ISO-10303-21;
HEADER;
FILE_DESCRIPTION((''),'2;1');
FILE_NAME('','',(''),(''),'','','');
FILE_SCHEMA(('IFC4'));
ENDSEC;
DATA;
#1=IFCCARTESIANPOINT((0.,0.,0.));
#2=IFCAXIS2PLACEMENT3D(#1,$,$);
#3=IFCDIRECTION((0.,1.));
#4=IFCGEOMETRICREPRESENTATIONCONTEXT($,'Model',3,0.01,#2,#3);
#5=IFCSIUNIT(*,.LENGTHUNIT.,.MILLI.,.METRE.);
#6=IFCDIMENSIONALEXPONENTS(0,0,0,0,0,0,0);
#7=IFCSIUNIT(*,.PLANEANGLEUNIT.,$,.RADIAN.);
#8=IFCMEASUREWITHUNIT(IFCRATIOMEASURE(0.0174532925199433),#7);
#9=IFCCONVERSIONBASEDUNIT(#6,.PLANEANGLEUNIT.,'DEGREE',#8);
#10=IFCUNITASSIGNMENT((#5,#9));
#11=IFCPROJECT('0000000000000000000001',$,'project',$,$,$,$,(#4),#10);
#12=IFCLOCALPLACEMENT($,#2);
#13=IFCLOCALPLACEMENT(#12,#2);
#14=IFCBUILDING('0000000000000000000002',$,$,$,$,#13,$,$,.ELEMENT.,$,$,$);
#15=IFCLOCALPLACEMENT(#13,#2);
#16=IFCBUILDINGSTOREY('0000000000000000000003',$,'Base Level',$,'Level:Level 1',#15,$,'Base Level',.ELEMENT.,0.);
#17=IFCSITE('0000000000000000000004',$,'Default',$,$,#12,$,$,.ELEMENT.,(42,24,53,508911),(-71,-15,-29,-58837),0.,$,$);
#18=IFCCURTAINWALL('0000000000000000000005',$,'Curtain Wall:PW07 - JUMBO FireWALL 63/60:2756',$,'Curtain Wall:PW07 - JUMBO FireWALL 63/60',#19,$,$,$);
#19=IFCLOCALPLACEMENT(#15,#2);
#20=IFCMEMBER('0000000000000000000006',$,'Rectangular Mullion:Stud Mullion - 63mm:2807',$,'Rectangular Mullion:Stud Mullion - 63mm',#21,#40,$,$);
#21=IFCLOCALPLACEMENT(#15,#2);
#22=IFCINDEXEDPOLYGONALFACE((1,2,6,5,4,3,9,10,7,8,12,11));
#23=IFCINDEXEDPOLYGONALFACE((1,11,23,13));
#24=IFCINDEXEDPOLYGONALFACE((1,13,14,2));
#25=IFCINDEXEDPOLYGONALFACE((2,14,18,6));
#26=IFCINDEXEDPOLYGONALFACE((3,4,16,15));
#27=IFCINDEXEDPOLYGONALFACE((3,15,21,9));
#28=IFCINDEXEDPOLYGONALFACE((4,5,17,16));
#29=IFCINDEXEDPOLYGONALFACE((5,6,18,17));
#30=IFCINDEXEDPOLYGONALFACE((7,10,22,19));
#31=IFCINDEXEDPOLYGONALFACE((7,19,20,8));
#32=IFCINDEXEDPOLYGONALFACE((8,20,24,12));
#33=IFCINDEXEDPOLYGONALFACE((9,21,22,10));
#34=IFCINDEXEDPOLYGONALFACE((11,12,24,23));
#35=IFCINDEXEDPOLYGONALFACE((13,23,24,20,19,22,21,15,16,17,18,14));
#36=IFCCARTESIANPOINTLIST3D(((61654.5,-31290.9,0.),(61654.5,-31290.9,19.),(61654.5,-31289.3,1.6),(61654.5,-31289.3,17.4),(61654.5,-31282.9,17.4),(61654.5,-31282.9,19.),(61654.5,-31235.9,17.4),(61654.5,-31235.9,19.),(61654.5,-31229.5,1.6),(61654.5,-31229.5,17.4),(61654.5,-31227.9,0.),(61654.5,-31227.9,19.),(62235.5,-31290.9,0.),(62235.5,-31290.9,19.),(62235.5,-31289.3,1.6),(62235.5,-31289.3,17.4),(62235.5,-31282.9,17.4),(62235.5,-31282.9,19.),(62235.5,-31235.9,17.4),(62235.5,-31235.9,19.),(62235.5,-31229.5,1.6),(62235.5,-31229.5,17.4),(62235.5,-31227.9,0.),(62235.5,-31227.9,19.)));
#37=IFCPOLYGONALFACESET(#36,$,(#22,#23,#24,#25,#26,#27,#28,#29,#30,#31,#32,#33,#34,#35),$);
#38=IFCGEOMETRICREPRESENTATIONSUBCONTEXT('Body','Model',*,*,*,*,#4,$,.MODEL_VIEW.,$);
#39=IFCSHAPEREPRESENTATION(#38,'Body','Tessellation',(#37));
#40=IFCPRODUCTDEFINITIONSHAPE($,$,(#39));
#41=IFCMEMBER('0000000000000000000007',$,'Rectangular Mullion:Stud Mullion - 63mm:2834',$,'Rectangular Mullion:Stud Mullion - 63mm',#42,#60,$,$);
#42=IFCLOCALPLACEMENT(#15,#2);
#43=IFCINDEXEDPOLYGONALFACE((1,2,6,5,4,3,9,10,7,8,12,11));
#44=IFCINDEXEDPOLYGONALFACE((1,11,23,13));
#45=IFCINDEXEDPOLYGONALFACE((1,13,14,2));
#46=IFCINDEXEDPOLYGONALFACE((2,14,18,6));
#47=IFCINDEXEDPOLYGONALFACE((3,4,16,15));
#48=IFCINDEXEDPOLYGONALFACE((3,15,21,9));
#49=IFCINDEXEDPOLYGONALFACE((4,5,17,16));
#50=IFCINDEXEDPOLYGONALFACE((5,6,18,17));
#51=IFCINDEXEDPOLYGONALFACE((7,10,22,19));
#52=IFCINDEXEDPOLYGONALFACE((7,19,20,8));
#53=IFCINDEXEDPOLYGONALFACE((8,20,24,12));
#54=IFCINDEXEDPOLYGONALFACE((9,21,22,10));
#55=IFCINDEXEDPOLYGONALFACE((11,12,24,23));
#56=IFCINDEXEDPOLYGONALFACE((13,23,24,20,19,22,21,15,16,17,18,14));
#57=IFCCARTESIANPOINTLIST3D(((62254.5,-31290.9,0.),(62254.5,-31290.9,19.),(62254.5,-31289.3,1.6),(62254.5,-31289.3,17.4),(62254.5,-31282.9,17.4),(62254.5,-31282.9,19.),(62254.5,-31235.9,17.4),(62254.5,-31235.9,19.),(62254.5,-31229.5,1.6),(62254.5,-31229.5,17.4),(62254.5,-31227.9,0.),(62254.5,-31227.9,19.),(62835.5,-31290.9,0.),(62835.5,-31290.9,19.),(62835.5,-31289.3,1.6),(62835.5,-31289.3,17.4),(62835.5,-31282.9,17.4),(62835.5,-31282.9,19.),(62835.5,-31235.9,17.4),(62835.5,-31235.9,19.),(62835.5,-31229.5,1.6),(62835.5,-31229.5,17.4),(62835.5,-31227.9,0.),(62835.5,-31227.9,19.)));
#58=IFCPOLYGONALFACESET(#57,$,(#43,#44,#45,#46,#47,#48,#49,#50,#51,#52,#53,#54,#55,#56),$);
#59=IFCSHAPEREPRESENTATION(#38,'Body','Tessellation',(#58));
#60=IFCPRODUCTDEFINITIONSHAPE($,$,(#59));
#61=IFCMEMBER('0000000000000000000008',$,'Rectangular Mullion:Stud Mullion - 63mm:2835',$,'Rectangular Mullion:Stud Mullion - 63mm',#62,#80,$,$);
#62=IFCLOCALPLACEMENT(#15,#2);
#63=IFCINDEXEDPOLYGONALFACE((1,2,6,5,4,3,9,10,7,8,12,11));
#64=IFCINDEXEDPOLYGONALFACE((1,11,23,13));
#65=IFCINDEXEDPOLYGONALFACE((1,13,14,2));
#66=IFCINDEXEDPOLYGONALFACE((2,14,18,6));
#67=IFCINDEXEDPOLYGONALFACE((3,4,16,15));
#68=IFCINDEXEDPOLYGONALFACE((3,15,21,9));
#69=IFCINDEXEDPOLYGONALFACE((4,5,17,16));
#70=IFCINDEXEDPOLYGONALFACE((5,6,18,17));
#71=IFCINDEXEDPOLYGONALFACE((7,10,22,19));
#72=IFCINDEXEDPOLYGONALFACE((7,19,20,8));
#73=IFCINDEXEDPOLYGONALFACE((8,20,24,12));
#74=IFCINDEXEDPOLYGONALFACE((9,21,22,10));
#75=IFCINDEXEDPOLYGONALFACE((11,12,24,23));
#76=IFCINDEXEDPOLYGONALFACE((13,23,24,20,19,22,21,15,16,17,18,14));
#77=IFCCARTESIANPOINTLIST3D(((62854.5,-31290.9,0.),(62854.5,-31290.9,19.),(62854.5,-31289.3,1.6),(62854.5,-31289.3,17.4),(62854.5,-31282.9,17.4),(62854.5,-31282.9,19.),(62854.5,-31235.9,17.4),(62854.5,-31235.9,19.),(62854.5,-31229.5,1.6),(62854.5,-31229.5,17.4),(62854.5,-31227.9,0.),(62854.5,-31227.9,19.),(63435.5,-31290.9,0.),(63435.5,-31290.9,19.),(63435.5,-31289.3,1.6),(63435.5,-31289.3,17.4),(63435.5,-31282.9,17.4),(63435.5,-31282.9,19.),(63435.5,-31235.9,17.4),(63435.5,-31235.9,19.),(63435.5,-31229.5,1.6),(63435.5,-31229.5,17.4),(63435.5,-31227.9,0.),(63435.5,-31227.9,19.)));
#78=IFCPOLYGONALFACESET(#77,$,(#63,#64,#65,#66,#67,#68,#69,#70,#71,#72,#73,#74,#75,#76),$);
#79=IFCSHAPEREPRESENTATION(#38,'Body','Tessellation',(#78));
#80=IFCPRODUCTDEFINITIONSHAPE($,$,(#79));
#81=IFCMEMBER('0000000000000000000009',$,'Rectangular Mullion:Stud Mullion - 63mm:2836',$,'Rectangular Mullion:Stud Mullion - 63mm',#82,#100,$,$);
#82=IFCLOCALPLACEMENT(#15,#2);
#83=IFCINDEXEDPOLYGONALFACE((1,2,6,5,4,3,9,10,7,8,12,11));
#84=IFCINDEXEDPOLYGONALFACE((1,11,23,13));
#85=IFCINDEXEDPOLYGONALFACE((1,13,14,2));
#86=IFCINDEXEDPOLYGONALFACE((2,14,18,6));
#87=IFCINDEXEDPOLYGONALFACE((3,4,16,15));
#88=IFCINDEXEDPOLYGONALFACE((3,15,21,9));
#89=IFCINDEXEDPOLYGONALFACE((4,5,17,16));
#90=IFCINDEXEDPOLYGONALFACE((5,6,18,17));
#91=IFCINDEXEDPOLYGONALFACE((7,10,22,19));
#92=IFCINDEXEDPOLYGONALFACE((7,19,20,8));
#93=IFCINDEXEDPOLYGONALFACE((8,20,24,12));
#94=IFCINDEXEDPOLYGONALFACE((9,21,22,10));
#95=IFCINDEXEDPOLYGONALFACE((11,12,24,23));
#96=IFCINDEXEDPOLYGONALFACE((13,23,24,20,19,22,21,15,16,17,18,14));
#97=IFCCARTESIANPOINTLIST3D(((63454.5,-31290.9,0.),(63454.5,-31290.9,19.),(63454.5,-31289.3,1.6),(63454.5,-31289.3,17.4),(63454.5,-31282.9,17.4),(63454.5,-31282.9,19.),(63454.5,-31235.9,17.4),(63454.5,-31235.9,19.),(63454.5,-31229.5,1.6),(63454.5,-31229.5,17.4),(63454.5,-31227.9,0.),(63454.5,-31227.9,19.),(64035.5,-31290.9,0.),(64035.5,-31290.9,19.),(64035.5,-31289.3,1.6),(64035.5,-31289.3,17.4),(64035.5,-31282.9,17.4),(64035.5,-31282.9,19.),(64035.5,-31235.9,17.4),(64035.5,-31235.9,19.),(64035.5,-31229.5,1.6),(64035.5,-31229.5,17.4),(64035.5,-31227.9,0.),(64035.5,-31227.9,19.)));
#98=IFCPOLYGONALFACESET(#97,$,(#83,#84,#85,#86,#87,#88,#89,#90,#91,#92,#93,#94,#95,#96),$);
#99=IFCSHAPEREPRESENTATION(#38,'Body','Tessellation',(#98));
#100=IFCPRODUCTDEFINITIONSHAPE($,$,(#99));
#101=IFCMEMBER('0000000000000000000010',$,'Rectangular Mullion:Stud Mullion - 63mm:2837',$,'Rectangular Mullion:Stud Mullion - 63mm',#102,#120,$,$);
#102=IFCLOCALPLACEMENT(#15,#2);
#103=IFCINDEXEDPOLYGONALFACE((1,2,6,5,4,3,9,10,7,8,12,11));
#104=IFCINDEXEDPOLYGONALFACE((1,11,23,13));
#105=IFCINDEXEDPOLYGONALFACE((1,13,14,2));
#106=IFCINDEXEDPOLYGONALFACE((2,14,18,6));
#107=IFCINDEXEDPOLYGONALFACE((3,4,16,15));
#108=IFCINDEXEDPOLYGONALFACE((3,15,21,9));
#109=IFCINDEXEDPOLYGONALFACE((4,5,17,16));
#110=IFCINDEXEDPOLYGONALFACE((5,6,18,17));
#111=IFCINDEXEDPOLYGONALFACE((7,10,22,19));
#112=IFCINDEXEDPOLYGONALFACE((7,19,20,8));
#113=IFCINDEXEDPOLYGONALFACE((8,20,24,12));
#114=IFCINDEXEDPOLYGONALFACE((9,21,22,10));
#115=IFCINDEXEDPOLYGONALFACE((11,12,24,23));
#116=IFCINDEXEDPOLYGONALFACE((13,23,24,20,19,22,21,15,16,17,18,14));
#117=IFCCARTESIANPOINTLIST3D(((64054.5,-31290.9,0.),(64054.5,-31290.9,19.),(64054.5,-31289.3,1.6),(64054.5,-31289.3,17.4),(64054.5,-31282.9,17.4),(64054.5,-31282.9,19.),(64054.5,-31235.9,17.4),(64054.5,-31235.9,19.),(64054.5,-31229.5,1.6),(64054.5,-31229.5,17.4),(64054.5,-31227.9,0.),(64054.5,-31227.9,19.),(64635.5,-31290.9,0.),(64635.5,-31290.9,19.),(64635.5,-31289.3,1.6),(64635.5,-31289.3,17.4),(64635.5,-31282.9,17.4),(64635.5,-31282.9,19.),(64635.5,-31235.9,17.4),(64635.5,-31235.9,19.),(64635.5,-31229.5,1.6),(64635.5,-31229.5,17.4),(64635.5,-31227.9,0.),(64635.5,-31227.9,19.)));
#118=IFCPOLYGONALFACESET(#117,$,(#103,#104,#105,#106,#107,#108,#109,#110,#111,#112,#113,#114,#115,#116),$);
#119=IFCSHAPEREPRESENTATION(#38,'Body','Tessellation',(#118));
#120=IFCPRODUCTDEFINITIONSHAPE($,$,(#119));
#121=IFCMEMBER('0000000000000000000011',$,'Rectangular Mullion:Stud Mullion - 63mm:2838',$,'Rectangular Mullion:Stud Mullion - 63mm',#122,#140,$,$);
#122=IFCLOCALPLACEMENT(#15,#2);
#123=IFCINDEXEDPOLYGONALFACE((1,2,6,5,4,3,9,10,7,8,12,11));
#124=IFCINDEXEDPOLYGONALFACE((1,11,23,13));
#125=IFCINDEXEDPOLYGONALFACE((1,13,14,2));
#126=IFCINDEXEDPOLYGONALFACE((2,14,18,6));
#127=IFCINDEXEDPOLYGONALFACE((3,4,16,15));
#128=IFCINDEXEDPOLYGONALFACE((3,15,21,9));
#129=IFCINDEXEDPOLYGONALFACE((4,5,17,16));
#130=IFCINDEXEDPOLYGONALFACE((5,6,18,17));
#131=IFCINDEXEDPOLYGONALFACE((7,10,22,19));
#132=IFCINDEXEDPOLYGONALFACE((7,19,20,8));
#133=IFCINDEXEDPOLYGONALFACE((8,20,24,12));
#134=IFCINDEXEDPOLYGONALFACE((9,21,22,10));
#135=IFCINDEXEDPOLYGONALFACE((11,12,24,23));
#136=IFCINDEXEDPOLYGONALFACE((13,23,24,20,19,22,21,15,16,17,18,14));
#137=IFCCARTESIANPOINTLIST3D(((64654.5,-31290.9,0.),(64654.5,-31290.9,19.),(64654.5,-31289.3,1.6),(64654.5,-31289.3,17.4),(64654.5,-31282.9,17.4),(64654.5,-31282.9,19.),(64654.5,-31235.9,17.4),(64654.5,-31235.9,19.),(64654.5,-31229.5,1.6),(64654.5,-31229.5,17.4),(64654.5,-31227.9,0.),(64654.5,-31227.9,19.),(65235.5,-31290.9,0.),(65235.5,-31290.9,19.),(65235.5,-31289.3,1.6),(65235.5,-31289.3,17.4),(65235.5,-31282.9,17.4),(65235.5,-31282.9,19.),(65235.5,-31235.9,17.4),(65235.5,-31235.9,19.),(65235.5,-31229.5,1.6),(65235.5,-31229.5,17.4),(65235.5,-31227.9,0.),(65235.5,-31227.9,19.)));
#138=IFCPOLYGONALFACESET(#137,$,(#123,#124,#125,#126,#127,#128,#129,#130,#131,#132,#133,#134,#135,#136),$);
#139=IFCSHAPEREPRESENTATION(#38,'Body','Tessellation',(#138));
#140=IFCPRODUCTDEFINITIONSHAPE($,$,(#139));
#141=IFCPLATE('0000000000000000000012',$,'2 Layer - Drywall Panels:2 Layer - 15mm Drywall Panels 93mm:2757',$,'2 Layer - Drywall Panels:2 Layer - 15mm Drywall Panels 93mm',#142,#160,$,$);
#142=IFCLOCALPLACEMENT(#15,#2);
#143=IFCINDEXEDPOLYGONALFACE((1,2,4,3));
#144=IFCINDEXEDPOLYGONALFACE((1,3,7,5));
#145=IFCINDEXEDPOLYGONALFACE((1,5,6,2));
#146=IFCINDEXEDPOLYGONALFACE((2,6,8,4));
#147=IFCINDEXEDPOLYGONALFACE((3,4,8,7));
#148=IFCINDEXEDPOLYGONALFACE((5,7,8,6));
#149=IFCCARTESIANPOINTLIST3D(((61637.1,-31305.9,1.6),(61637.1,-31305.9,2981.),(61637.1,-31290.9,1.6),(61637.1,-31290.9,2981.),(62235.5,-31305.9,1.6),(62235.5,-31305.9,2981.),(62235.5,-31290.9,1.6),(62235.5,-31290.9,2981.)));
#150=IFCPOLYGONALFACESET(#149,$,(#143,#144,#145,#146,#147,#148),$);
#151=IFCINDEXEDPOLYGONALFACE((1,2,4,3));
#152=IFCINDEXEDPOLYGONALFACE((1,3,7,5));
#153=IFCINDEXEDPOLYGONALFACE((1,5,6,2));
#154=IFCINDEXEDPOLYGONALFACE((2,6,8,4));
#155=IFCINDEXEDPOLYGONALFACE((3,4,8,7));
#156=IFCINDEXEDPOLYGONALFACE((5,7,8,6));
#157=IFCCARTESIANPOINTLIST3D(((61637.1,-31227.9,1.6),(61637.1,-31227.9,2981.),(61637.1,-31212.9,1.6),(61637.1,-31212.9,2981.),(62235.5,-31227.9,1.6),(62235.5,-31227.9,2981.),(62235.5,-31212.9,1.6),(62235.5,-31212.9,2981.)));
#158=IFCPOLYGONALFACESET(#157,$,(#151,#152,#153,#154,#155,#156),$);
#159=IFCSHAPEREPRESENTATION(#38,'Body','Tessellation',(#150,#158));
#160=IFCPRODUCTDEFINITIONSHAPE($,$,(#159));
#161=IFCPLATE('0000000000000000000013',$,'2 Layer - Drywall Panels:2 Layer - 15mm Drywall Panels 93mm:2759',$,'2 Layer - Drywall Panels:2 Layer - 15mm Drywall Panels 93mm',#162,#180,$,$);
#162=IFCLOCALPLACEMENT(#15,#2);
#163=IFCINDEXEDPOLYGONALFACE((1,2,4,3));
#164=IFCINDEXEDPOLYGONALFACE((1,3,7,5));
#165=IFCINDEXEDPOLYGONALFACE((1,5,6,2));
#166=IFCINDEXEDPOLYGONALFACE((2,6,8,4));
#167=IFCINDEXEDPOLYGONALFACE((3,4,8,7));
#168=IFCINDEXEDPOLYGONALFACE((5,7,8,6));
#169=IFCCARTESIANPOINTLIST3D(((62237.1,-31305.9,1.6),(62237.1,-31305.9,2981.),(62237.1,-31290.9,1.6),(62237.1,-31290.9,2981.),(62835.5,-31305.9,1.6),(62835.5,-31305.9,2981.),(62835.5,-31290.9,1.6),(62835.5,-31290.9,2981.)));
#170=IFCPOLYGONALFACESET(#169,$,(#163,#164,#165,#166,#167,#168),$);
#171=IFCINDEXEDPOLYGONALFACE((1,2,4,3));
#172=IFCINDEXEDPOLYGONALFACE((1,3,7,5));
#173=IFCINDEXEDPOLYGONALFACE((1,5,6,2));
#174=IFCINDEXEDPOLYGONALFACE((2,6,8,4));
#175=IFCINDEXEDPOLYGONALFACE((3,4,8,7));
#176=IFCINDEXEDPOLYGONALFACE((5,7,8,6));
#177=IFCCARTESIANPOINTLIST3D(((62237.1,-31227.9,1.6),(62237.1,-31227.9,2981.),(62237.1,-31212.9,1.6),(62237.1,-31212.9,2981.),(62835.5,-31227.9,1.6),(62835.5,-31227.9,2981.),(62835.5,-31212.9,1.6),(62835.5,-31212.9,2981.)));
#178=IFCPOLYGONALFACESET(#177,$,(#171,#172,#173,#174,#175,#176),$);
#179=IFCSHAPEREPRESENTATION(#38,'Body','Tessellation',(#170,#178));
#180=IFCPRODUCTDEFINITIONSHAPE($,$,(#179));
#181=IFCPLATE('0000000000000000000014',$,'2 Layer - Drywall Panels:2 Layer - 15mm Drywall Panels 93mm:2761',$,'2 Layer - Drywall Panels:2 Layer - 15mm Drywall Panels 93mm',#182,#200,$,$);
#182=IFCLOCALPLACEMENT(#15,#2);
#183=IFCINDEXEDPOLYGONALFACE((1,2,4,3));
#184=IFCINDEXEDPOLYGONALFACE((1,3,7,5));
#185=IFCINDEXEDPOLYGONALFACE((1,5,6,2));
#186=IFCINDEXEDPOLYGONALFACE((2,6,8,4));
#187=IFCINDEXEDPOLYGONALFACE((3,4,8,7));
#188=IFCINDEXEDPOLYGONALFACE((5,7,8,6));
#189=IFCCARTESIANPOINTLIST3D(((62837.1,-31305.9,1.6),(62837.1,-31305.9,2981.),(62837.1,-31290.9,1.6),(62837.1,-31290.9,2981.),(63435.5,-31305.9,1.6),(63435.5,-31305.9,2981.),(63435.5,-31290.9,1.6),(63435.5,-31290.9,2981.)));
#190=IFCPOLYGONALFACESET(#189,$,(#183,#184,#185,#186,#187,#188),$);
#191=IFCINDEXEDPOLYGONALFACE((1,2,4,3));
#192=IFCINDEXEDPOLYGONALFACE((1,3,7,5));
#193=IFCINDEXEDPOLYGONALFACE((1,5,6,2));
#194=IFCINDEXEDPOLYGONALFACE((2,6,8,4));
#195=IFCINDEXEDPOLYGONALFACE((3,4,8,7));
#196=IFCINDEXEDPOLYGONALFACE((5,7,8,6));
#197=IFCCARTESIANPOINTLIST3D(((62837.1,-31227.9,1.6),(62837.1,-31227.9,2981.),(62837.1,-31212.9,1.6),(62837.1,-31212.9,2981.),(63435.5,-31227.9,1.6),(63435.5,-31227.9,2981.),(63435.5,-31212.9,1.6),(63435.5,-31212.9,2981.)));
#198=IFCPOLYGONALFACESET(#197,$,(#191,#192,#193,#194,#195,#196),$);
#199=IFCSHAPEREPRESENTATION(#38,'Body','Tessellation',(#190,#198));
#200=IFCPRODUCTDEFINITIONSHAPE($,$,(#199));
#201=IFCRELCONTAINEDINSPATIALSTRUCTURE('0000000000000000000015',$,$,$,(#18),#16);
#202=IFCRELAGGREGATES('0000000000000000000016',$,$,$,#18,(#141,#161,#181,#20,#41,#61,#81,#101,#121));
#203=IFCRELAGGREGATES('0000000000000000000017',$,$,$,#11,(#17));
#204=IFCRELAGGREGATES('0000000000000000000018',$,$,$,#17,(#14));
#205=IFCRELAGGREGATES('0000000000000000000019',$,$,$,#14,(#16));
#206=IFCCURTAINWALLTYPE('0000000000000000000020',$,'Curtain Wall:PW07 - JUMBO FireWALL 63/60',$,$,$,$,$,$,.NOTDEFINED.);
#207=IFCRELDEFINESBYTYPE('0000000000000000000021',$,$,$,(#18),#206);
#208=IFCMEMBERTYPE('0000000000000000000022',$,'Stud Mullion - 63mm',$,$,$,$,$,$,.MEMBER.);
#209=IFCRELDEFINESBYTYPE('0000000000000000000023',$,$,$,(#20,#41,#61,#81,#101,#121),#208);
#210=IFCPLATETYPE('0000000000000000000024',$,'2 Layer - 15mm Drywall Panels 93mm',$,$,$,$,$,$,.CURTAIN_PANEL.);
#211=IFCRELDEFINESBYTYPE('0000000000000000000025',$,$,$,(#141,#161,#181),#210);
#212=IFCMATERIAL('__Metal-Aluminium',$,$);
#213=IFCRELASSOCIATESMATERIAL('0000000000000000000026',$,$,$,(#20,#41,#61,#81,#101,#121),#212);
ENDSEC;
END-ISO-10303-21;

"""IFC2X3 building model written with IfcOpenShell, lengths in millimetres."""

from ifc_helpers import new_model, entity, si_unit, converted_unit, direction, frame, frame_2d, origin, place, context, subcontext, project, spatial, polyline, rectangle, outline, extrude, source, transform, mapped, material, type_object, type_shapes, element, aggregate, save


model = new_model("IFC2X3")

# Units and contexts
model_context = context("Model", 3, precision=0.01, world=origin(), true_north=direction((0.0, 1.0)))
body_context = subcontext(model_context, "Body", "Model", "MODEL_VIEW")
ifc_project = project(units=[si_unit("LENGTHUNIT", "METRE", prefix="MILLI"), converted_unit("PLANEANGLEUNIT", "DEGREE", entity("IfcRatioMeasure", 0.0174532925199433), si_unit("PLANEANGLEUNIT", "RADIAN"), dimensions=[0, 0, 0, 0, 0, 0, 0])], contexts=[model_context])

# Site, building, storey
site_placement = place(None, origin())
site = spatial("IfcSite", under=ifc_project, at=site_placement, Name="Default", CompositionType="ELEMENT", RefLatitude=(42, 24, 53, 508911), RefLongitude=(-71, -15, -29, -58837), RefElevation=0.0)
building_placement = place(site_placement, origin())
building = spatial("IfcBuilding", under=site, at=building_placement, CompositionType="ELEMENT")
storey_placement = place(building_placement, origin())
storey = spatial("IfcBuildingStorey", under=building, at=storey_placement, Name="Base Level", ObjectType="Level:Level 1", LongName="Base Level", CompositionType="ELEMENT", Elevation=0.0)

# Curtain wall, members, plates
curtain_wall_type = type_object("IfcCurtainWallType", Name="Curtain Wall:PW07 - JUMBO FireWALL 63/60", PredefinedType="NOTDEFINED")
curtain_wall_placement = place(building_placement, origin())
curtain_wall = element("IfcCurtainWall", 1, at=curtain_wall_placement, inside=storey, type_object=curtain_wall_type, Name="Curtain Wall:PW07 - JUMBO FireWALL 63/60:2756", ObjectType="Curtain Wall:PW07 - JUMBO FireWALL 63/60")
ifc_material_1 = material(Name="__Metal-Aluminium")
member_type_1 = type_object("IfcMemberType", Name="Stud Mullion - 63mm", PredefinedType="MEMBER")
shared_shape_1 = source(origin(), body_context, "Body", "SweptSolid", [
    extrude(outline(polyline([(23.5, -6.6), (31.5, -6.6), (31.5, 12.4), (-31.5, 12.4), (-31.5, -6.6), (-23.5, -6.6), (-23.5, -5.0), (-29.9, -5.0), (-29.9, 10.8), (29.9, 10.8), (29.9, -5.0), (23.5, -5.0), (23.5, -6.6)])), frame((-12.4, 0.0, -581.0), z_axis=(0.0, 0.0, 1.0), x_axis=(0.0, -1.0, 0.0)), (0.0, 0.0, 1.0), 581.0),
])
type_shapes(member_type_1, [shared_shape_1])
member_1_placement = place(building_placement, frame((61654.5, -31259.4, 0.0), z_axis=(-1.0, 0.0, 0.0), x_axis=(0.0, 0.0, -1.0)))
member_1 = element("IfcMember", 2, at=member_1_placement, type_object=member_type_1, material=ifc_material_1, Name="Rectangular Mullion:Stud Mullion - 63mm:2807", ObjectType="Rectangular Mullion:Stud Mullion - 63mm", context=body_context, shape_type="MappedRepresentation", body=[
    mapped(shared_shape_1, transform((0.0, 0.0, 0.0), scale=1.0)),
])
member_2_placement = place(building_placement, frame((62254.5, -31259.4, 0.0), z_axis=(-1.0, 0.0, 0.0), x_axis=(0.0, 0.0, -1.0)))
member_2 = element("IfcMember", 3, at=member_2_placement, type_object=member_type_1, material=ifc_material_1, Name="Rectangular Mullion:Stud Mullion - 63mm:2834", ObjectType="Rectangular Mullion:Stud Mullion - 63mm", context=body_context, shape_type="MappedRepresentation", body=[
    mapped(shared_shape_1, transform((0.0, 0.0, 0.0), scale=1.0)),
])
member_3_placement = place(building_placement, frame((62854.5, -31259.4, 0.0), z_axis=(-1.0, 0.0, 0.0), x_axis=(0.0, 0.0, -1.0)))
member_3 = element("IfcMember", 4, at=member_3_placement, type_object=member_type_1, material=ifc_material_1, Name="Rectangular Mullion:Stud Mullion - 63mm:2835", ObjectType="Rectangular Mullion:Stud Mullion - 63mm", context=body_context, shape_type="MappedRepresentation", body=[
    mapped(shared_shape_1, transform((0.0, 0.0, 0.0), scale=1.0)),
])
member_4_placement = place(building_placement, frame((63454.5, -31259.4, 0.0), z_axis=(-1.0, 0.0, 0.0), x_axis=(0.0, 0.0, -1.0)))
member_4 = element("IfcMember", 5, at=member_4_placement, type_object=member_type_1, material=ifc_material_1, Name="Rectangular Mullion:Stud Mullion - 63mm:2836", ObjectType="Rectangular Mullion:Stud Mullion - 63mm", context=body_context, shape_type="MappedRepresentation", body=[
    mapped(shared_shape_1, transform((0.0, 0.0, 0.0), scale=1.0)),
])
member_5_placement = place(building_placement, frame((64054.5, -31259.4, 0.0), z_axis=(-1.0, 0.0, 0.0), x_axis=(0.0, 0.0, -1.0)))
member_5 = element("IfcMember", 6, at=member_5_placement, type_object=member_type_1, material=ifc_material_1, Name="Rectangular Mullion:Stud Mullion - 63mm:2837", ObjectType="Rectangular Mullion:Stud Mullion - 63mm", context=body_context, shape_type="MappedRepresentation", body=[
    mapped(shared_shape_1, transform((0.0, 0.0, 0.0), scale=1.0)),
])
member_6_placement = place(building_placement, frame((64654.5, -31259.4, 0.0), z_axis=(-1.0, 0.0, 0.0), x_axis=(0.0, 0.0, -1.0)))
member_6 = element("IfcMember", 7, at=member_6_placement, type_object=member_type_1, material=ifc_material_1, Name="Rectangular Mullion:Stud Mullion - 63mm:2838", ObjectType="Rectangular Mullion:Stud Mullion - 63mm", context=body_context, shape_type="MappedRepresentation", body=[
    mapped(shared_shape_1, transform((0.0, 0.0, 0.0), scale=1.0)),
])
plate_type = type_object("IfcPlateType", Name="2 Layer - 15mm Drywall Panels 93mm", PredefinedType="CURTAIN_PANEL")
shared_shape_2 = source(origin(), body_context, "Body", "SweptSolid", [
    extrude(rectangle(XDim=598.4, YDim=15.0, at=frame_2d((0.0, 0.0), x_axis=(1.0, 0.0))), frame((0.0, -39.0, 0.0), z_axis=(0.0, 0.0, 1.0), x_axis=(-1.0, 0.0, 0.0)), (0.0, 0.0, 1.0), 2979.4),
    extrude(rectangle(XDim=15.0, YDim=598.4, at=frame_2d((0.0, 0.0), x_axis=(1.0, 0.0))), frame((0.0, 39.0, 0.0), z_axis=(0.0, 0.0, 1.0), x_axis=(0.0, 1.0, 0.0)), (0.0, 0.0, 1.0), 2979.4),
])
type_shapes(plate_type, [shared_shape_2])
plate_1_placement = place(curtain_wall_placement, frame((61936.3, -31259.4, 1.6)))
plate_1 = element("IfcPlate", 8, at=plate_1_placement, type_object=plate_type, Name="2 Layer - Drywall Panels:2 Layer - 15mm Drywall Panels 93mm:2757", ObjectType="2 Layer - Drywall Panels:2 Layer - 15mm Drywall Panels 93mm", context=body_context, shape_type="MappedRepresentation", body=[
    mapped(shared_shape_2, transform((0.0, 0.0, 0.0), scale=1.0)),
])
plate_2_placement = place(curtain_wall_placement, frame((62536.3, -31259.4, 1.6)))
plate_2 = element("IfcPlate", 9, at=plate_2_placement, type_object=plate_type, Name="2 Layer - Drywall Panels:2 Layer - 15mm Drywall Panels 93mm:2759", ObjectType="2 Layer - Drywall Panels:2 Layer - 15mm Drywall Panels 93mm", context=body_context, shape_type="MappedRepresentation", body=[
    mapped(shared_shape_2, transform((0.0, 0.0, 0.0), scale=1.0)),
])
plate_3_placement = place(curtain_wall_placement, frame((63136.3, -31259.4, 1.6)))
plate_3 = element("IfcPlate", 10, at=plate_3_placement, type_object=plate_type, Name="2 Layer - Drywall Panels:2 Layer - 15mm Drywall Panels 93mm:2761", ObjectType="2 Layer - Drywall Panels:2 Layer - 15mm Drywall Panels 93mm", context=body_context, shape_type="MappedRepresentation", body=[
    mapped(shared_shape_2, transform((0.0, 0.0, 0.0), scale=1.0)),
])
aggregate(curtain_wall, [plate_1, plate_2, plate_3, member_1, member_2, member_3, member_4, member_5, member_6])

save(model, "model.ifc")
